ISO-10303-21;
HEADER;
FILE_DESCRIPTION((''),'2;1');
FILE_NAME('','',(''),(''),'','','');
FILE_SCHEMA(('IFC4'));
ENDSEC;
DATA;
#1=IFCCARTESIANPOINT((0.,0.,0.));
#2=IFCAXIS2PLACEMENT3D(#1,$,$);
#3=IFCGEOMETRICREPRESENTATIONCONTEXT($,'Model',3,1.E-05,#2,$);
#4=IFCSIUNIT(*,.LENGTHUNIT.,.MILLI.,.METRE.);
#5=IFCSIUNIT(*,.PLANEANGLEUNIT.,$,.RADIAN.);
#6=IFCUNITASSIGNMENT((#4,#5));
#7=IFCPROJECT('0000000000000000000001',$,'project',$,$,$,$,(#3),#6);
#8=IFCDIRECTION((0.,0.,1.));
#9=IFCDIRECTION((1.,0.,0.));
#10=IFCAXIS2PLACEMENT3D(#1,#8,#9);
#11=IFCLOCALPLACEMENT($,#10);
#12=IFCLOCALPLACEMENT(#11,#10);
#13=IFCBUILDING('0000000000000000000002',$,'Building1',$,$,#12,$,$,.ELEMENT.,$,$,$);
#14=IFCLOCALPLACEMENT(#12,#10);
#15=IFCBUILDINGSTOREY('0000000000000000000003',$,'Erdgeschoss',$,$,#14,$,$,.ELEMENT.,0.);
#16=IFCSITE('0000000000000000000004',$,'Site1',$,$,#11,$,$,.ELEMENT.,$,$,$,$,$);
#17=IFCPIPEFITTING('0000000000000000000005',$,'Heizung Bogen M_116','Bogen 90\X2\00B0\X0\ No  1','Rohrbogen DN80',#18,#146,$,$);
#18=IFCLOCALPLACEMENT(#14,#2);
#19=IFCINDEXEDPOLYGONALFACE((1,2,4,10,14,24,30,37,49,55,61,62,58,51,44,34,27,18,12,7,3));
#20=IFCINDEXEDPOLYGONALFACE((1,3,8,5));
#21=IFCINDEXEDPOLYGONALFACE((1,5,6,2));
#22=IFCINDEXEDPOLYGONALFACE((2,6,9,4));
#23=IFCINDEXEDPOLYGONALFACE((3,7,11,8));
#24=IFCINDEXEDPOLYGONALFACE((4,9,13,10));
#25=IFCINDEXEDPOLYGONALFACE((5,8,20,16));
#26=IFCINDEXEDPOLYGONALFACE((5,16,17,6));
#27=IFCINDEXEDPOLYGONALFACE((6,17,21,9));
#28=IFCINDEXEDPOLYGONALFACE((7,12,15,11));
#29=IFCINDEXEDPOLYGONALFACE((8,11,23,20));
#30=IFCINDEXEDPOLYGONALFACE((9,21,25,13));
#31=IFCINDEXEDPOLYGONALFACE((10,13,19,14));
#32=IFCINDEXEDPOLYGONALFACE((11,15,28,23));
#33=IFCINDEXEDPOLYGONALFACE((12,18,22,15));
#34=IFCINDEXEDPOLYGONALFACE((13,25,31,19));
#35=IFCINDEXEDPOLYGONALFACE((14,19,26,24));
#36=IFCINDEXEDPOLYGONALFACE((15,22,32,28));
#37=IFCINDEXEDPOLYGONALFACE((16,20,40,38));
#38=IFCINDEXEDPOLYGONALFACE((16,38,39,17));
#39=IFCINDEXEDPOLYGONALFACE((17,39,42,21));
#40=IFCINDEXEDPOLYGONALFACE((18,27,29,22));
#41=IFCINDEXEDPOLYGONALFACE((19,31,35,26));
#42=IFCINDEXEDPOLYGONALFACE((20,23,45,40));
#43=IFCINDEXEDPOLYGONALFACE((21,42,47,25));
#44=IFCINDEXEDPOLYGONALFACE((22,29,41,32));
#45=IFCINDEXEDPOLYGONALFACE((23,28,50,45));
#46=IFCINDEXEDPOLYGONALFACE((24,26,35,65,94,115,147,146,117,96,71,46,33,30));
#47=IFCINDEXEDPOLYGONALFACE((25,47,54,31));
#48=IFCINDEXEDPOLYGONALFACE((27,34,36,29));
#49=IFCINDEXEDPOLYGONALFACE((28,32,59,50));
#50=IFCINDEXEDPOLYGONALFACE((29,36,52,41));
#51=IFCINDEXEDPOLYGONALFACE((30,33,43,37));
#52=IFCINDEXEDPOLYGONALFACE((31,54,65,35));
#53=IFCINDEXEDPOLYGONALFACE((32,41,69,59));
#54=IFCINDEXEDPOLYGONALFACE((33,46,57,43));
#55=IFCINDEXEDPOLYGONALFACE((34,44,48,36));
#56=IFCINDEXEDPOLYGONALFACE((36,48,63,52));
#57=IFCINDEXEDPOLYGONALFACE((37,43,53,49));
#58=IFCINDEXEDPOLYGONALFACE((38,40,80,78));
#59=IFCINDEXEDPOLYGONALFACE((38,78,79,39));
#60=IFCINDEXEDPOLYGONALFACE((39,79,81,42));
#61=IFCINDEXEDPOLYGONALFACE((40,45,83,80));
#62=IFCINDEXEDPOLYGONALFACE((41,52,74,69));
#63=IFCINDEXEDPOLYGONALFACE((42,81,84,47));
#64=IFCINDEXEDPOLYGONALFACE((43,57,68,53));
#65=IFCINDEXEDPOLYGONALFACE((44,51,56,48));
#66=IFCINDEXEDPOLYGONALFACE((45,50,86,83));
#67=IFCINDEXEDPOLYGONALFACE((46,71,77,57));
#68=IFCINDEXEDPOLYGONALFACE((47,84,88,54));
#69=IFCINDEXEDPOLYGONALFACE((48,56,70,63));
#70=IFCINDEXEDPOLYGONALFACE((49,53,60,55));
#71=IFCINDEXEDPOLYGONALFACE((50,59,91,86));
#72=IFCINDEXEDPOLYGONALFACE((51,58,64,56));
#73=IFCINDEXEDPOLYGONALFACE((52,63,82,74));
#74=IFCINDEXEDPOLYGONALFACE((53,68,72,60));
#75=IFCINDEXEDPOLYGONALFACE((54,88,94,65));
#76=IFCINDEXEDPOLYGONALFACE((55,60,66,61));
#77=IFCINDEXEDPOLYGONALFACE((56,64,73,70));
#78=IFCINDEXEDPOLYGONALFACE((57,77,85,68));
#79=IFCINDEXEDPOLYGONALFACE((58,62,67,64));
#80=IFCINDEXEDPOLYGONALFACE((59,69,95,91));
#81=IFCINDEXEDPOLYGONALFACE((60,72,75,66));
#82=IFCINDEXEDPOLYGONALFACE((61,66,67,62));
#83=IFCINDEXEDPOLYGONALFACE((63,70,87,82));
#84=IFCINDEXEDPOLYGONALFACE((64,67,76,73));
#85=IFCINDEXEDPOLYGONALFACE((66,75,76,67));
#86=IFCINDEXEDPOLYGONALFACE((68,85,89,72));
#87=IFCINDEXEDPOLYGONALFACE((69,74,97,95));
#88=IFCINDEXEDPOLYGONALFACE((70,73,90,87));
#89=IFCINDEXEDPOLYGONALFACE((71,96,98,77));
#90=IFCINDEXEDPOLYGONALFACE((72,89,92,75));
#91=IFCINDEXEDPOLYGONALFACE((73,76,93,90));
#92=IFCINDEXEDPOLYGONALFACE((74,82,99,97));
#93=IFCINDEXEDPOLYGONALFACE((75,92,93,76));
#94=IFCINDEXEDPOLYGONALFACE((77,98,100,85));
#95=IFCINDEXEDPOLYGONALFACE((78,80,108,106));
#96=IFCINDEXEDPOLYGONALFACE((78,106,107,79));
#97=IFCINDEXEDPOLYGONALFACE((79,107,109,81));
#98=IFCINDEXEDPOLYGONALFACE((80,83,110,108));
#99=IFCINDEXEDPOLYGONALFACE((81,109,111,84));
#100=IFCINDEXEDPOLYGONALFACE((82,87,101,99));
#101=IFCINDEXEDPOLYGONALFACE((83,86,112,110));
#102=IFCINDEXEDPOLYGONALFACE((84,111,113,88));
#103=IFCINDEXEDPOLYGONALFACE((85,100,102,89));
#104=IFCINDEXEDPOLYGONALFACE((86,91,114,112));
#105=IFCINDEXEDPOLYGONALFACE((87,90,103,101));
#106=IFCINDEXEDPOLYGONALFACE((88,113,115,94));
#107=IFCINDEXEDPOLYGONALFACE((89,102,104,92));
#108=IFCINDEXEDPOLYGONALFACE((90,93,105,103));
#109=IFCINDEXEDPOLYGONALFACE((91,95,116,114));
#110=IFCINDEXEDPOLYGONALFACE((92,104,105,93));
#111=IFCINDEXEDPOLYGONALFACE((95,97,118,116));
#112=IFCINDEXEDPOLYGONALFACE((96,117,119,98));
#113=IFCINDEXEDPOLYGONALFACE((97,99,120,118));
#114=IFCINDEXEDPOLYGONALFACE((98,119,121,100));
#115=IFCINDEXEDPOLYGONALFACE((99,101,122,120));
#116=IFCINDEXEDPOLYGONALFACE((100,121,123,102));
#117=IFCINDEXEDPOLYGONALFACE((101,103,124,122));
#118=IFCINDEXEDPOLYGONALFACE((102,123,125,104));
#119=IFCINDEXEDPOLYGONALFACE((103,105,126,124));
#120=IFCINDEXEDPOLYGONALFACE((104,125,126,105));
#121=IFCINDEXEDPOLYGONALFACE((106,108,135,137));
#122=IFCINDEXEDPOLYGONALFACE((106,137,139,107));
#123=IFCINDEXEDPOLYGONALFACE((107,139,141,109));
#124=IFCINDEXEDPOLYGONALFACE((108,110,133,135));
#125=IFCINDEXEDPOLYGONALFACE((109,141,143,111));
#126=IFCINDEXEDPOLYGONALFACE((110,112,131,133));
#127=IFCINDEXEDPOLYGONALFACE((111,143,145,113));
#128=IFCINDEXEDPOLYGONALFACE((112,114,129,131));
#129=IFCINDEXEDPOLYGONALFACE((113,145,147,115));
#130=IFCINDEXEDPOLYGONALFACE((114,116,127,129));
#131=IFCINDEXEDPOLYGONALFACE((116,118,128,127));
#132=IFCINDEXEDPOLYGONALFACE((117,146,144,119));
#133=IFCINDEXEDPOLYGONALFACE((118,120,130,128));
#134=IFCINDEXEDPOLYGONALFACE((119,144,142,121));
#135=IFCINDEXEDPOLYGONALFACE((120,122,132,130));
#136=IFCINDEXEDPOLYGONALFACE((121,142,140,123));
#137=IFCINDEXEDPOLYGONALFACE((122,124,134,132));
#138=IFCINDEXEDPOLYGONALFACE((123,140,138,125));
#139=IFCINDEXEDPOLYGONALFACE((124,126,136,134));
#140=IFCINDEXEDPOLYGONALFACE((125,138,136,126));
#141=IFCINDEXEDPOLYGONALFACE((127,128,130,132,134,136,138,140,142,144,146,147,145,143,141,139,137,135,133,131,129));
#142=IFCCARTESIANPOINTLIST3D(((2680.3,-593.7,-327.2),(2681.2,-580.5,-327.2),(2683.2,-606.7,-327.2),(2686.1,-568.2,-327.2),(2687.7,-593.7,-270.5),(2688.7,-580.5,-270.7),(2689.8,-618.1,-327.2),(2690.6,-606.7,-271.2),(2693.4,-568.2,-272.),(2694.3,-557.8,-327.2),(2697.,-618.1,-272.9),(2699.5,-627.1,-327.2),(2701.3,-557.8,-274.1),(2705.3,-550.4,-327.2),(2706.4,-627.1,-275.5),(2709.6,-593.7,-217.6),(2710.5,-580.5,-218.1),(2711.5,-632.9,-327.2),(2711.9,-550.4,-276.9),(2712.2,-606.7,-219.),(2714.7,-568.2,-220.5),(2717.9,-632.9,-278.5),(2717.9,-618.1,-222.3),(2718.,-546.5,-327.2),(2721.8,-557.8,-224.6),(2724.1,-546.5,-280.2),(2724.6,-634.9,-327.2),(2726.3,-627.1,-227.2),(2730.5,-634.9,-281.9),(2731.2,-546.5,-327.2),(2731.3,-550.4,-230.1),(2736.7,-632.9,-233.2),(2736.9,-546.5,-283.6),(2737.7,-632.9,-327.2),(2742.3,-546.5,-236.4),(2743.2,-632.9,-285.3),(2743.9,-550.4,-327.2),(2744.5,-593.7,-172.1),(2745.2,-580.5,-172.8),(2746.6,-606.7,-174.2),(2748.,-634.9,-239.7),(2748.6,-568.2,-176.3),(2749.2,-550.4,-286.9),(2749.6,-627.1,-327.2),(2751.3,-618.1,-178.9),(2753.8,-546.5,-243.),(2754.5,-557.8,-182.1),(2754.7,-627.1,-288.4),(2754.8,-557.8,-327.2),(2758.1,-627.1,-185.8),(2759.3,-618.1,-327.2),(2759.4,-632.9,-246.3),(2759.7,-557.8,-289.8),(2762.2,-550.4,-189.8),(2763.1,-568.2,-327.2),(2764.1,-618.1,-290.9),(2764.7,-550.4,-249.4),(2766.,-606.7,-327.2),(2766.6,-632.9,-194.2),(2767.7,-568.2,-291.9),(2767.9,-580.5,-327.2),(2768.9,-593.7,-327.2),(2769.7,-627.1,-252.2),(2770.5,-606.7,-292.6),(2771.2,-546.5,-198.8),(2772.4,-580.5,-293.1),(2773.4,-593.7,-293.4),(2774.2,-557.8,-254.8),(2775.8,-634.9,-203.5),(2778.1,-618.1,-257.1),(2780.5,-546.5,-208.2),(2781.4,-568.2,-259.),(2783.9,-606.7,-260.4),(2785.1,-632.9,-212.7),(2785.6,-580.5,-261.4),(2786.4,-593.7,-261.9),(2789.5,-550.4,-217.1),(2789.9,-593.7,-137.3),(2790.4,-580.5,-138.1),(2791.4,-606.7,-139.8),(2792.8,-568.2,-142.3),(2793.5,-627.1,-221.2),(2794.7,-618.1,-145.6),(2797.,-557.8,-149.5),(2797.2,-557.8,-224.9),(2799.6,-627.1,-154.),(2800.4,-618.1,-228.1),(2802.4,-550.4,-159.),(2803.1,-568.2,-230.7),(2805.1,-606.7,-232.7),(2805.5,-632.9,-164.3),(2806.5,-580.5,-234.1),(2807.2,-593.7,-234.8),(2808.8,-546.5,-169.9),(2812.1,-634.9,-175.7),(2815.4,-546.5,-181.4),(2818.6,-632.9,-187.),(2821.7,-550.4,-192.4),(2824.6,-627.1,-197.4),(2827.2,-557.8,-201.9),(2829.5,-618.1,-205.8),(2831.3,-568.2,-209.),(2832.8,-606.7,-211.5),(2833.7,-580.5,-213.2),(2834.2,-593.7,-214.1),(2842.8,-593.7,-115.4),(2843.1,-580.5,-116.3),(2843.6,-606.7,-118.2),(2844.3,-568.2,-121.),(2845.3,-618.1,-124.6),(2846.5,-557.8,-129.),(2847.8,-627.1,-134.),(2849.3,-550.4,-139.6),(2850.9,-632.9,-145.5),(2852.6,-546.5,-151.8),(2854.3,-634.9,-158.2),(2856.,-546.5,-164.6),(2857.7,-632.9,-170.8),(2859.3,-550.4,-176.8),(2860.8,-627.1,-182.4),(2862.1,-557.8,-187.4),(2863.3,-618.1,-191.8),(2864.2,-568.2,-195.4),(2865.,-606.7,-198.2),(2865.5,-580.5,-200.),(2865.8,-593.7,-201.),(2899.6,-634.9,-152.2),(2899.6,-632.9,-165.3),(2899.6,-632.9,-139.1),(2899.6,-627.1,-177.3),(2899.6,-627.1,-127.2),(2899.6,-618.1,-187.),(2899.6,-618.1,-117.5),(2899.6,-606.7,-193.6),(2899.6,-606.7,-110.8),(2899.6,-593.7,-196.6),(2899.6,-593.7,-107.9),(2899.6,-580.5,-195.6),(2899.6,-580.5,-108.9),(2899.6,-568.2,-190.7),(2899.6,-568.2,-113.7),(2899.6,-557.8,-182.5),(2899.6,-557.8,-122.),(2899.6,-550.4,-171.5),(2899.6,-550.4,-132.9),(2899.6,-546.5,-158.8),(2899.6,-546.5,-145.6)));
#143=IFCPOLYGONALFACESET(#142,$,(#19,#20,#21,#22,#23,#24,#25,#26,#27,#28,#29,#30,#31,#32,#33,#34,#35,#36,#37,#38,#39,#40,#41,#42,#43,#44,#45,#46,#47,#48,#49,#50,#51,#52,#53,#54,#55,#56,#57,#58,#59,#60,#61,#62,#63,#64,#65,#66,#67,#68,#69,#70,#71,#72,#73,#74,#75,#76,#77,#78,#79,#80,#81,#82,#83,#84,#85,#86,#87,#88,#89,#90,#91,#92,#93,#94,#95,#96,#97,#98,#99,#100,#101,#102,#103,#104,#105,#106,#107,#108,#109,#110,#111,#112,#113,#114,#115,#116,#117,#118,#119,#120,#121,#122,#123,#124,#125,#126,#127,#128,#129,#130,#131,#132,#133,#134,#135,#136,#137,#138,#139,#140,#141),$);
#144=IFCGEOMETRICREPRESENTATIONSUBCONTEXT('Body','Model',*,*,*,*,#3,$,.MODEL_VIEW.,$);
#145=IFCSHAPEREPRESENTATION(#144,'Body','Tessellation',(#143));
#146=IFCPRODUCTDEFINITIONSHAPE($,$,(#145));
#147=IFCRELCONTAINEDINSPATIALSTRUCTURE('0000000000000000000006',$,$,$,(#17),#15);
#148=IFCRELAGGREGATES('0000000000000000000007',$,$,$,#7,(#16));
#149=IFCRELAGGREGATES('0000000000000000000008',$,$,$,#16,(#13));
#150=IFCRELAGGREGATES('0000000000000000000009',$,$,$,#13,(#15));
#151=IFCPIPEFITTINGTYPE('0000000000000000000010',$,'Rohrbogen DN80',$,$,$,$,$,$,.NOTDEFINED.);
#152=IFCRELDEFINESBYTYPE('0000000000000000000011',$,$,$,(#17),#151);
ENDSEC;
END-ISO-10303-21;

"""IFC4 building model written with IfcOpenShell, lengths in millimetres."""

from ifc_helpers import new_model, entity, si_unit, frame, origin, origin_with_axes, place, context, subcontext, project, spatial, shape, source, transform, mapped, type_object, element, save


model = new_model("IFC4")

# Units and contexts
model_context = context("Model", 3, precision=1e-05, world=origin())
body_context = subcontext(model_context, "Body", "Model", "MODEL_VIEW")
ifc_project = project(units=[si_unit("LENGTHUNIT", "METRE", prefix="MILLI"), si_unit("PLANEANGLEUNIT", "RADIAN")], contexts=[model_context])

# Site, building, storey
site_placement = place(None, origin_with_axes())
site = spatial("IfcSite", under=ifc_project, at=site_placement, Name="Site1", CompositionType="ELEMENT")
building_placement = place(site_placement, origin_with_axes())
building = spatial("IfcBuilding", under=site, at=building_placement, Name="Building1", CompositionType="ELEMENT")
storey_placement = place(building_placement, origin_with_axes())
storey = spatial("IfcBuildingStorey", under=building, at=storey_placement, Name="Erdgeschoss", CompositionType="ELEMENT", Elevation=0.0)

# Shared definitions
pipe_fitting_type_1 = type_object("IfcPipeFittingType", Name="Rohrbogen DN80", PredefinedType="NOTDEFINED")

# Pipe fitting
shared_shape_1 = source(origin_with_axes(), body_context, "Body", "SolidModel", [
    entity("IfcRevolvedAreaSolid", entity("IfcCircleProfileDef", "AREA", None, entity("IfcAxis2Placement2D", entity("IfcCartesianPoint", [0.0, 0.0]), entity("IfcDirection", [1.0, 0.0])), 44.5), entity("IfcAxis2Placement3D", entity("IfcCartesianPoint", [109.7, -65.3, 0.0]), entity("IfcDirection", [-1.0, 0.0, 0.0]), entity("IfcDirection", [0.0, 0.0, 1.0])), entity("IfcAxis1Placement", entity("IfcCartesianPoint", [0.0, 175.0, 0.0]), entity("IfcDirection", [-1.0, 0.0, 0.0])), 1.570796),
])
pipe_fitting_1_placement = place(storey_placement, frame((2789.9, -590.4, -217.5), z_axis=(0.0, 0.0, 1.0), x_axis=(1.0, 0.0, 0.0)))
element("IfcPipeFitting", 1, at=pipe_fitting_1_placement, inside=storey, type_object=pipe_fitting_type_1, Name="Heizung Bogen M_116", Description="Bogen 90° No  1", ObjectType="Rohrbogen DN80", shapes=[
    shape(body_context, "Body", "MappedRepresentation", [mapped(shared_shape_1, transform((0.0, 0.0, 0.0), x_axis=(0.0, 0.0, -1.0), y_axis=(1.0, 0.0, 0.0), z_axis=(0.0, -1.0, 0.0), scale=1.0))]),
    shape(body_context, "Body", "MappedRepresentation", [mapped(shared_shape_1, transform((0.0, 0.0, 0.0), x_axis=(0.0, 0.0, -1.0), y_axis=(1.0, 0.0, 0.0), z_axis=(0.0, -1.0, 0.0), scale=1.0))]),
])

save(model, "model.ifc")
